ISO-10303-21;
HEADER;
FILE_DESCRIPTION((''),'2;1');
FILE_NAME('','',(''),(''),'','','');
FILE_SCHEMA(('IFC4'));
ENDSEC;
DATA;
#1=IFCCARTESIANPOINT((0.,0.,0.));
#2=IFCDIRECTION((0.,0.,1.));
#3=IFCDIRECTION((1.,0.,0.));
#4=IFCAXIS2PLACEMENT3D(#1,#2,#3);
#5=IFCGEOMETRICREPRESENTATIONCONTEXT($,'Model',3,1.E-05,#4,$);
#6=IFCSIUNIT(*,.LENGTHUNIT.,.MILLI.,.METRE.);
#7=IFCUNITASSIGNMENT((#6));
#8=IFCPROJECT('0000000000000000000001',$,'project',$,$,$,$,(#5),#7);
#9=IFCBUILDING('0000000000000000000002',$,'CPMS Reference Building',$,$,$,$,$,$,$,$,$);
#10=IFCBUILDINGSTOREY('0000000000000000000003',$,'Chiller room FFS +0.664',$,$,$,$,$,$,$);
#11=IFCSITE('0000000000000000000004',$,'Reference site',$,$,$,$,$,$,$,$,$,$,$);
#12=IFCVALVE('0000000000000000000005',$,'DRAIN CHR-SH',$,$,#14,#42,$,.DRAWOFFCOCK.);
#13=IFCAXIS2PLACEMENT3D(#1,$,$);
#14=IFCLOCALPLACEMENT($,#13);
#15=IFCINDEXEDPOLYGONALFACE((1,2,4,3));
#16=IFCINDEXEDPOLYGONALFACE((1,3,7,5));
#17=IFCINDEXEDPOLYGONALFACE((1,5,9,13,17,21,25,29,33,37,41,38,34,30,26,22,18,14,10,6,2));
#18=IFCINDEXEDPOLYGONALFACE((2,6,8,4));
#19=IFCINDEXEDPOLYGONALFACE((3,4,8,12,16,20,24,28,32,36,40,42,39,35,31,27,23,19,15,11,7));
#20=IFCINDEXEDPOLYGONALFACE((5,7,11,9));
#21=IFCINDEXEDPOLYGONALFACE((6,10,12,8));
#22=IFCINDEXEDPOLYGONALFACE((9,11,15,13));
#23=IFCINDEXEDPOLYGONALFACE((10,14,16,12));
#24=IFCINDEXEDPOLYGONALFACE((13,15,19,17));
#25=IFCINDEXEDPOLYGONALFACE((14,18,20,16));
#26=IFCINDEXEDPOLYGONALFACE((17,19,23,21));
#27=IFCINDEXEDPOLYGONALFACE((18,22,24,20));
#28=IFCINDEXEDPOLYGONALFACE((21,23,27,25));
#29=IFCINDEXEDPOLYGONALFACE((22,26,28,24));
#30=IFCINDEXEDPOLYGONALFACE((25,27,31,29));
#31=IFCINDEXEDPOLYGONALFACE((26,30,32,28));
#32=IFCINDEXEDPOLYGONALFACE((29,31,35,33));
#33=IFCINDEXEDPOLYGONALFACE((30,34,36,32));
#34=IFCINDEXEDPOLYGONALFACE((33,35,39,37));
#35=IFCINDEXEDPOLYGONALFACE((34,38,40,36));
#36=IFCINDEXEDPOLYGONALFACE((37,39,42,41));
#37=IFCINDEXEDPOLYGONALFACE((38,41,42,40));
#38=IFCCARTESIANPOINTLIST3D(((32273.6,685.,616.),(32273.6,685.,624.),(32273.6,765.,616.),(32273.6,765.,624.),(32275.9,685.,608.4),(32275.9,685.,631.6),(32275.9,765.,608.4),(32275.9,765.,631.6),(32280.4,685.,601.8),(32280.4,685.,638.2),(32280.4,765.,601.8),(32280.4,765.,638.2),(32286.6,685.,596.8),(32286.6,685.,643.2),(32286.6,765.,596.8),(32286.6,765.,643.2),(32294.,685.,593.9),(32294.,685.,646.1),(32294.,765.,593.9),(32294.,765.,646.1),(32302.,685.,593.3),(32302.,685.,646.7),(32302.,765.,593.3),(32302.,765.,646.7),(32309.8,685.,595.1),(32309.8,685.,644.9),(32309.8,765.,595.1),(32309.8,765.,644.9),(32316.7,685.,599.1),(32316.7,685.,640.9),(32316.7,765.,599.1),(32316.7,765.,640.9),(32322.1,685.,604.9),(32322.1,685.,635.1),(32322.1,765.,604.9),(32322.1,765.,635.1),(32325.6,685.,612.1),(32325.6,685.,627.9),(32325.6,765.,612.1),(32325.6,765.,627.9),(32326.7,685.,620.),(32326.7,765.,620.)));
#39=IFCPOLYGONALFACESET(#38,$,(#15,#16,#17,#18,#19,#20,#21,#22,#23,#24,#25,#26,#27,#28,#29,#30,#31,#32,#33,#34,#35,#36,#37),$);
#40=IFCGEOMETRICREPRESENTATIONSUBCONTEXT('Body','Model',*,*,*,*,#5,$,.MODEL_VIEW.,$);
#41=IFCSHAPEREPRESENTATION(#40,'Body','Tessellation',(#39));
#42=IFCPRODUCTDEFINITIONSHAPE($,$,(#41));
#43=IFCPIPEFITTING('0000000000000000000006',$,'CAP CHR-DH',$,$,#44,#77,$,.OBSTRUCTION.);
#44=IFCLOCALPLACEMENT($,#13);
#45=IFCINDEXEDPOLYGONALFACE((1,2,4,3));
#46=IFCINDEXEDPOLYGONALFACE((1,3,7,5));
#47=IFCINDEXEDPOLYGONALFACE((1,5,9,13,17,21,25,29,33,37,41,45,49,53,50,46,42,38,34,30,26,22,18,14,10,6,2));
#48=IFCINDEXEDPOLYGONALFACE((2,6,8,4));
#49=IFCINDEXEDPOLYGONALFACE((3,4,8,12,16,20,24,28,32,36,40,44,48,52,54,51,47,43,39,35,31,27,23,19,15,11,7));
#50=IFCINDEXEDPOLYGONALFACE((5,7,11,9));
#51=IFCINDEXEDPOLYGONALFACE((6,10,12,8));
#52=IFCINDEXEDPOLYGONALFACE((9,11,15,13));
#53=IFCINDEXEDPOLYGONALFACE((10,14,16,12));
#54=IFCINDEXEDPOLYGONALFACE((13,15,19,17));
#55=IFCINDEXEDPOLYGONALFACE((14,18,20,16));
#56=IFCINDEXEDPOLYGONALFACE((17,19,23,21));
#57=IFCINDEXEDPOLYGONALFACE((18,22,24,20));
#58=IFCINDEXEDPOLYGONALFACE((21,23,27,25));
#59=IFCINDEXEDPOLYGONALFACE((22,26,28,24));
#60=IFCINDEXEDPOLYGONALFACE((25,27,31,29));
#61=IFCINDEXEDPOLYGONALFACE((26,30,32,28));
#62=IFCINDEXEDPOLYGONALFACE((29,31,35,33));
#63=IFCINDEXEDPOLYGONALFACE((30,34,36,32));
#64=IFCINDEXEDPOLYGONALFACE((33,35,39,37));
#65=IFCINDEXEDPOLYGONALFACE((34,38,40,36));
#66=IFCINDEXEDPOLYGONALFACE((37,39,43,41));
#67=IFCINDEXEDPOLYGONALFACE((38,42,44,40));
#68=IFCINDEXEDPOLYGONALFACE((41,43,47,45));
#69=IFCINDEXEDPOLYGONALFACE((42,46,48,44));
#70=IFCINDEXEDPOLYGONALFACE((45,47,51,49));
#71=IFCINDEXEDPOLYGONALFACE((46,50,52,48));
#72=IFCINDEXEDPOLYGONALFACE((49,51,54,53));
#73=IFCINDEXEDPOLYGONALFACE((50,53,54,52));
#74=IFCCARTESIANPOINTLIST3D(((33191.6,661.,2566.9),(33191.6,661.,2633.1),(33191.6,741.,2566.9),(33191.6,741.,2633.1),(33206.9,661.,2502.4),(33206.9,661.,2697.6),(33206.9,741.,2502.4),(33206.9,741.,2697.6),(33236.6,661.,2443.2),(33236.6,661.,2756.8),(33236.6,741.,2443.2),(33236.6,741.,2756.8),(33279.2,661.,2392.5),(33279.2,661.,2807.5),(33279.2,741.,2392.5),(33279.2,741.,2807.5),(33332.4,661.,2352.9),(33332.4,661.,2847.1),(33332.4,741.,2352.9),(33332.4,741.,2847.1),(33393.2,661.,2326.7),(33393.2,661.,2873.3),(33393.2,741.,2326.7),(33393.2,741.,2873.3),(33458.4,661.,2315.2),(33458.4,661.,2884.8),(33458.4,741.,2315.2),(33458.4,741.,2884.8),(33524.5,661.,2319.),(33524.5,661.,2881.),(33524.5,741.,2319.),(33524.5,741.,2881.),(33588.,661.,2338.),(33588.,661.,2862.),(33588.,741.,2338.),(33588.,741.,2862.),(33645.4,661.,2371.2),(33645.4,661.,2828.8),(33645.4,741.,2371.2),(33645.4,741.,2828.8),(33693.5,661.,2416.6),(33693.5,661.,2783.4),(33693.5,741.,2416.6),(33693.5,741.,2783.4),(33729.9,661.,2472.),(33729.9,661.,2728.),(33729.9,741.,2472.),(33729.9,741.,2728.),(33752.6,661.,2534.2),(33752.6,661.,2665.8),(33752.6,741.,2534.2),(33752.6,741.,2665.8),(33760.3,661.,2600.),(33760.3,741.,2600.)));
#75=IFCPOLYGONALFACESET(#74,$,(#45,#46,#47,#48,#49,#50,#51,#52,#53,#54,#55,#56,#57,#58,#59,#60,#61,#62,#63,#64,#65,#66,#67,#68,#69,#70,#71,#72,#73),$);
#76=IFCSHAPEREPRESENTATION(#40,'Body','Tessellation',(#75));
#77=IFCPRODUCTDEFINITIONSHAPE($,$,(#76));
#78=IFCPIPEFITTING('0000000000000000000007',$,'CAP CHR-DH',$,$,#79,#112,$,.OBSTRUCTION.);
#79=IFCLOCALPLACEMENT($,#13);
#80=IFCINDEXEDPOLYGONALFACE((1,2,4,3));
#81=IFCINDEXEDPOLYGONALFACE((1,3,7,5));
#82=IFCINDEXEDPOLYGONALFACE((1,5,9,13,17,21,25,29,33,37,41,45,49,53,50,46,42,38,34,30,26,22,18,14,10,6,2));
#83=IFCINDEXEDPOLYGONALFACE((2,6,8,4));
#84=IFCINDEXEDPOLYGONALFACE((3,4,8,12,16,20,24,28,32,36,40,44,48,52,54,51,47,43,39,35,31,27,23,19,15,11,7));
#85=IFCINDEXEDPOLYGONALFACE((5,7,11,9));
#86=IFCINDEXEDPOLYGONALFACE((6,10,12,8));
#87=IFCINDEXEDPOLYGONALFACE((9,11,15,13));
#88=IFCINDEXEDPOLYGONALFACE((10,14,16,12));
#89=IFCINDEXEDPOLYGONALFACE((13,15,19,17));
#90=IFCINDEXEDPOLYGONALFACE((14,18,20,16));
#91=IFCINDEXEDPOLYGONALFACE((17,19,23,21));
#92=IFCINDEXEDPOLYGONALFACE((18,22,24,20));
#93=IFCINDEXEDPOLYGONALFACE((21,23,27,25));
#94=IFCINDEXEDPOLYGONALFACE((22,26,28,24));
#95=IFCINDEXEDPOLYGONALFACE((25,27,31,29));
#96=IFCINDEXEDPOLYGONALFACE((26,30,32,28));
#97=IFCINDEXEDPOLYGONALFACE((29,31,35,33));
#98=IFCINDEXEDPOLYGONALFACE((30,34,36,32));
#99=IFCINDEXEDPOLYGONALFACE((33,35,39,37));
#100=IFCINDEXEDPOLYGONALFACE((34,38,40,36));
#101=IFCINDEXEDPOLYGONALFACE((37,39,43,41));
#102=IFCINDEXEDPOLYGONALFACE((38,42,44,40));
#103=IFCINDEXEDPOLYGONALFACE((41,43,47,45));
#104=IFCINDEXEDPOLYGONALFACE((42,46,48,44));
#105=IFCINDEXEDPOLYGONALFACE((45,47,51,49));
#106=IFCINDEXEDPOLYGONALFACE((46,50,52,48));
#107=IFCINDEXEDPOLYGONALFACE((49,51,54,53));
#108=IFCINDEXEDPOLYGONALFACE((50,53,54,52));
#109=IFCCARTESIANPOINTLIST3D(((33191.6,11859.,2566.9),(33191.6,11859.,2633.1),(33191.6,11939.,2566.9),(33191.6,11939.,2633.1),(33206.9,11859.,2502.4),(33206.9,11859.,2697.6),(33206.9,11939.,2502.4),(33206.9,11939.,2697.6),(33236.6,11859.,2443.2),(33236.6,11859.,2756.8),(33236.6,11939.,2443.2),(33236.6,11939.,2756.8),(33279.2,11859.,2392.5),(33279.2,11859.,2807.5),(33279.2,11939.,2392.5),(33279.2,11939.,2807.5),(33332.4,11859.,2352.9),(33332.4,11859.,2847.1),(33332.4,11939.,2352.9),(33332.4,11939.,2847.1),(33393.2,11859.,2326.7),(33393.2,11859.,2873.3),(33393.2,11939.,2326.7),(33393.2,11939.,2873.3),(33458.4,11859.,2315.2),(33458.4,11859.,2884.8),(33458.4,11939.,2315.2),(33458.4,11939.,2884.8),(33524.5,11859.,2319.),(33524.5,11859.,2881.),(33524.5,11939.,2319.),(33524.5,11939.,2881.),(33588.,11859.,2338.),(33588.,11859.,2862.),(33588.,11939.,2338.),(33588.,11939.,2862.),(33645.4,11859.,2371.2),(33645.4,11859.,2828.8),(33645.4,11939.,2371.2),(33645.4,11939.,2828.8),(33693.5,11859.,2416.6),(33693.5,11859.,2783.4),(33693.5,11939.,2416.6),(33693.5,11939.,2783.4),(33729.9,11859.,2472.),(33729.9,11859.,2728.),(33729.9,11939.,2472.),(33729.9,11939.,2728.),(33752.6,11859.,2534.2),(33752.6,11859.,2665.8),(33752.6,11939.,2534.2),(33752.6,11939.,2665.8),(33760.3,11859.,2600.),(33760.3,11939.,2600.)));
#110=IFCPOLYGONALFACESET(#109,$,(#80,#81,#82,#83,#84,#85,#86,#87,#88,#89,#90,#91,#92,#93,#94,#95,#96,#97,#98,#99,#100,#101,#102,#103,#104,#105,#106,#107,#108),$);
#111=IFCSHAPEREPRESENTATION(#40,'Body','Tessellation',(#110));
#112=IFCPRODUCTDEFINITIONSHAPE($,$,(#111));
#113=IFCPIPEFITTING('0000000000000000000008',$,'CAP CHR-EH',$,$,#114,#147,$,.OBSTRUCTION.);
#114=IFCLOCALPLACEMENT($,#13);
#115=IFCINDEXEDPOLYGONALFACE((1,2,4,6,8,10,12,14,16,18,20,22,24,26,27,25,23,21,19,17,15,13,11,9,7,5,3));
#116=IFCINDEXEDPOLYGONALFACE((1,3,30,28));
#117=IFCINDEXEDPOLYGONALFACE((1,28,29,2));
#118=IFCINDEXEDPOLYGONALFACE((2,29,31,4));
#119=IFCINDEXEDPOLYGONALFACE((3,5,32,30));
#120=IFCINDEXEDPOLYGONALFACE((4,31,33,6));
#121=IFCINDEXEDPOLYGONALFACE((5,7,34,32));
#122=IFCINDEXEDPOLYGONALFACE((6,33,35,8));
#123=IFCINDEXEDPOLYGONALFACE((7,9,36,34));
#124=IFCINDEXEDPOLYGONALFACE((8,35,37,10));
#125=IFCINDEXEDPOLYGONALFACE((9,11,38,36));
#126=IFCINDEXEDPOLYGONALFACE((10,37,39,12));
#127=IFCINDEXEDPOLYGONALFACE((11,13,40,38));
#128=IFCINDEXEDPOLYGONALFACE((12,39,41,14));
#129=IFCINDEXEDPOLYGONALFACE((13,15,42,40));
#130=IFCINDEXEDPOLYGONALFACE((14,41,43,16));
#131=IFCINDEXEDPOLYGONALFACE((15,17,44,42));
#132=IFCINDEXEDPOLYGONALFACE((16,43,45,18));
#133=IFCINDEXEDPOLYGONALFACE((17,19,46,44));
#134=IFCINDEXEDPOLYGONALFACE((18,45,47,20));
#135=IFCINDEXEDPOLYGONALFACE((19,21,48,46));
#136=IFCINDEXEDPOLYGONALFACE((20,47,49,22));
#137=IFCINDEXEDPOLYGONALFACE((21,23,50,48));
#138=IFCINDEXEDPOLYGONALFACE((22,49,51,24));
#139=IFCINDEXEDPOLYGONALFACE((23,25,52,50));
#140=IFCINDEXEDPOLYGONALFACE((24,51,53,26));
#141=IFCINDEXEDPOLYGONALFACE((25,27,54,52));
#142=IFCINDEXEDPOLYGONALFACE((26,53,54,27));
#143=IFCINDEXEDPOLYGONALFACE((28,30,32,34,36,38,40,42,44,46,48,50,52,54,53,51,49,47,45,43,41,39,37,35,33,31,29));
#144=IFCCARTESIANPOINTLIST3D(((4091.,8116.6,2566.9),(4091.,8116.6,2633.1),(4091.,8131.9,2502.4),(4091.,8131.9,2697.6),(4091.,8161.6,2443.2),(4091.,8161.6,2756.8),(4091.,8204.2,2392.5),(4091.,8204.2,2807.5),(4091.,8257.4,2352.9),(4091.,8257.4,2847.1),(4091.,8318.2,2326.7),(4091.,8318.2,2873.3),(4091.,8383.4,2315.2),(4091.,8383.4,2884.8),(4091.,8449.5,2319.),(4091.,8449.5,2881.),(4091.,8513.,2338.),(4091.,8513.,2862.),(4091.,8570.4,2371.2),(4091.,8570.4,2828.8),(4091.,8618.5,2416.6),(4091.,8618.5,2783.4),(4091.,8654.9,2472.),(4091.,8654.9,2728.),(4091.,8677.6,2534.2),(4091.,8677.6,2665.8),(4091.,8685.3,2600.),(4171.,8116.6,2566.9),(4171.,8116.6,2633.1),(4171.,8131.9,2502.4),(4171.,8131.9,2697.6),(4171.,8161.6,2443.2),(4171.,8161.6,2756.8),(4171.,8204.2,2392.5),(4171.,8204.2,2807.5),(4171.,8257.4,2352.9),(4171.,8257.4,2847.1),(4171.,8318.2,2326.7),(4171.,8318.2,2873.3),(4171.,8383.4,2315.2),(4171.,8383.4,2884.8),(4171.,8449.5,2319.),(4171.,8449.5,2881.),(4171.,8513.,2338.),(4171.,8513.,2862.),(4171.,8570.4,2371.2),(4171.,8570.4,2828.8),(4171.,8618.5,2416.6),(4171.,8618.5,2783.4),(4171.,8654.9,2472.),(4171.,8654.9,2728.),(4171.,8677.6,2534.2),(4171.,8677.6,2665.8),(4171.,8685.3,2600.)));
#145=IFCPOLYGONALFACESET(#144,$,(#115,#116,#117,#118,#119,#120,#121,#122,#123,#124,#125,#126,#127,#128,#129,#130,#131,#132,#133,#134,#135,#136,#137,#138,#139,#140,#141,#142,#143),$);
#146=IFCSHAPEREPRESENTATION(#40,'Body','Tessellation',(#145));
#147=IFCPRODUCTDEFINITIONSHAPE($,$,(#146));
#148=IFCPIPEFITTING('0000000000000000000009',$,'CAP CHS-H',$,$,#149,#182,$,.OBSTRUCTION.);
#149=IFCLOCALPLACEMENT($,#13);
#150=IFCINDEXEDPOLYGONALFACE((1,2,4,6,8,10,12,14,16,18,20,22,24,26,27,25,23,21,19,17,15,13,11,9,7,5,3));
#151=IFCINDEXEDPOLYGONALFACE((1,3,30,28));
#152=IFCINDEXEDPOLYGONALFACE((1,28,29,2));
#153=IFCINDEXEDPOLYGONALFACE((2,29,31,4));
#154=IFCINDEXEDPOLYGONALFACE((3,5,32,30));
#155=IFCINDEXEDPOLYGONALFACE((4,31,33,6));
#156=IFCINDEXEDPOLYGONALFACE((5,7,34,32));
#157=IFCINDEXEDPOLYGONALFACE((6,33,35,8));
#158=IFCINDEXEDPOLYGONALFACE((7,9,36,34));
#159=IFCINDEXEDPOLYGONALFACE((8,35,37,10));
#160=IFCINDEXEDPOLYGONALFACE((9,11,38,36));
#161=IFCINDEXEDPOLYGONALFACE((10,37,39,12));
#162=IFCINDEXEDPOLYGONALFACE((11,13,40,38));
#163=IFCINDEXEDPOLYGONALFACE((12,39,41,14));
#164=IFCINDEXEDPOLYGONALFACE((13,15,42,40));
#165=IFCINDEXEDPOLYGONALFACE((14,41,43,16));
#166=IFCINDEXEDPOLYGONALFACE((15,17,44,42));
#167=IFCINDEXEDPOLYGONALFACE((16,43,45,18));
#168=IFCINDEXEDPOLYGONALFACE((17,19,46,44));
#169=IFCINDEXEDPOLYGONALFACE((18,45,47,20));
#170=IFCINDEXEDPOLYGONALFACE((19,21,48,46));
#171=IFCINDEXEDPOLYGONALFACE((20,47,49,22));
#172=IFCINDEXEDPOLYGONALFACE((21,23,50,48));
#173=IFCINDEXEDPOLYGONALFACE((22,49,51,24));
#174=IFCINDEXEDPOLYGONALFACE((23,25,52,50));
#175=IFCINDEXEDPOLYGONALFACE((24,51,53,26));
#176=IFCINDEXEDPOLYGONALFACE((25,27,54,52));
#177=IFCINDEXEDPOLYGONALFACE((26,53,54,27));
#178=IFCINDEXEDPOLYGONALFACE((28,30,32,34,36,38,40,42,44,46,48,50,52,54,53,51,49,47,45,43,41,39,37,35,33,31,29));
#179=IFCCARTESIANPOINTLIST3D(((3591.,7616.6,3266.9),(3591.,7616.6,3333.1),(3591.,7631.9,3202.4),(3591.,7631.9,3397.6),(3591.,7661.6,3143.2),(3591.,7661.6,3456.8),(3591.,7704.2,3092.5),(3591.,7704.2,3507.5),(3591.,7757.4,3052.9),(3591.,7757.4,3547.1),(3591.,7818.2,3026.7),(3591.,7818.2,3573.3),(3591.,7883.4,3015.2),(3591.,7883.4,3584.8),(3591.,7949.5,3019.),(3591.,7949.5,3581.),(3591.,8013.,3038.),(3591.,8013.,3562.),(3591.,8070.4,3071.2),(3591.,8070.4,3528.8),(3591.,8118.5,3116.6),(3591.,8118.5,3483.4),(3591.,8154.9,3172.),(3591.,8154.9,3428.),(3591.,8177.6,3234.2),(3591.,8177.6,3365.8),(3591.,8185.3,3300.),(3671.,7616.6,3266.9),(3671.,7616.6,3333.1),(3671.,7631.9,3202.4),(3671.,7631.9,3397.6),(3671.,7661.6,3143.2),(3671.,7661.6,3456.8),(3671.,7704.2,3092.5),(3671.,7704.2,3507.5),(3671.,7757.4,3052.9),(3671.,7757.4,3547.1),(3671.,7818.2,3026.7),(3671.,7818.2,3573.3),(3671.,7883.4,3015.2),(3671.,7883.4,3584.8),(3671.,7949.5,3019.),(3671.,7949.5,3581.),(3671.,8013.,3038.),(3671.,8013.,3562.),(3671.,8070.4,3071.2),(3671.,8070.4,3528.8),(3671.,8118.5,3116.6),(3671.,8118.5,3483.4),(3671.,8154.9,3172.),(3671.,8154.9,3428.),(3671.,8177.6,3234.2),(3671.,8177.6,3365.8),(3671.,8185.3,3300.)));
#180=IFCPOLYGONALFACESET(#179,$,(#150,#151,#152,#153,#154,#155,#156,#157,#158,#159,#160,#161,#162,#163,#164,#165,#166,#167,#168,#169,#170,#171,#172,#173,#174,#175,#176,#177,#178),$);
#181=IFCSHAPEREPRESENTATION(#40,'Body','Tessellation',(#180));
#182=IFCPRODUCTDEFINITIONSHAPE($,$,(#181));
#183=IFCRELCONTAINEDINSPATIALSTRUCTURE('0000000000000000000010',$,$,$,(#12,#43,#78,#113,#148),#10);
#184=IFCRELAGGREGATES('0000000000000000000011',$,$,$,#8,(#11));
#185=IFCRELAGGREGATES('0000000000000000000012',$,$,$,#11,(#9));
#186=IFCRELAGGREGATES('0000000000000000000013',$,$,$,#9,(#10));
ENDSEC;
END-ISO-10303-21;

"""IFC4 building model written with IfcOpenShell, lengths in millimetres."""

from ifc_helpers import new_model, si_unit, frame, origin_with_axes, origin_2d, place, context, subcontext, project, spatial, circle_curve, outline, extrude, element, save


model = new_model("IFC4")

# Units and contexts
model_context = context("Model", 3, precision=1e-05, world=origin_with_axes())
body_context = subcontext(model_context, "Body", "Model", "MODEL_VIEW")
ifc_project = project(units=[si_unit("LENGTHUNIT", "METRE", prefix="MILLI")], contexts=[model_context])

# Site, building, storey
site = spatial("IfcSite", under=ifc_project, Name="Reference site")
building = spatial("IfcBuilding", under=site, Name="CPMS Reference Building")
storey = spatial("IfcBuildingStorey", under=building, Name="Chiller room FFS +0.664")

# Valve
valve_1_placement = place(None, origin_with_axes())
element("IfcValve", 1, at=valve_1_placement, inside=storey, Name="DRAIN CHR-SH", PredefinedType="DRAWOFFCOCK", context=body_context, shape_type="SweptSolid", body=[
    extrude(outline(circle_curve(origin_2d(), 26.7)), frame((32300.0, 765.0, 620.0), z_axis=(0.0, -1.0, 0.0), x_axis=(1.0, 0.0, 0.0)), (0.0, 0.0, 1.0), 80.0),
])

# Pipe fittings
pipe_fitting_1_placement = place(None, origin_with_axes())
element("IfcPipeFitting", 2, at=pipe_fitting_1_placement, inside=storey, Name="CAP CHR-DH", PredefinedType="OBSTRUCTION", context=body_context, shape_type="SweptSolid", body=[
    extrude(outline(circle_curve(origin_2d(), 285.3)), frame((33475.0, 661.0, 2600.0), z_axis=(0.0, 1.0, 0.0), x_axis=(1.0, 0.0, 0.0)), (0.0, 0.0, 1.0), 80.0),
])
pipe_fitting_2_placement = place(None, origin_with_axes())
element("IfcPipeFitting", 3, at=pipe_fitting_2_placement, inside=storey, Name="CAP CHR-DH", PredefinedType="OBSTRUCTION", context=body_context, shape_type="SweptSolid", body=[
    extrude(outline(circle_curve(origin_2d(), 285.3)), frame((33475.0, 11859.0, 2600.0), z_axis=(0.0, 1.0, 0.0), x_axis=(1.0, 0.0, 0.0)), (0.0, 0.0, 1.0), 80.0),
])
pipe_fitting_3_placement = place(None, origin_with_axes())
element("IfcPipeFitting", 4, at=pipe_fitting_3_placement, inside=storey, Name="CAP CHR-EH", PredefinedType="OBSTRUCTION", context=body_context, shape_type="SweptSolid", body=[
    extrude(outline(circle_curve(origin_2d(), 285.3)), frame((4171.0, 8400.0, 2600.0), z_axis=(-1.0, 0.0, 0.0), x_axis=(0.0, 1.0, 0.0)), (0.0, 0.0, 1.0), 80.0),
])
pipe_fitting_4_placement = place(None, origin_with_axes())
element("IfcPipeFitting", 5, at=pipe_fitting_4_placement, inside=storey, Name="CAP CHS-H", PredefinedType="OBSTRUCTION", context=body_context, shape_type="SweptSolid", body=[
    extrude(outline(circle_curve(origin_2d(), 285.3)), frame((3591.0, 7900.0, 3300.0), z_axis=(1.0, 0.0, 0.0), x_axis=(0.0, 1.0, 0.0)), (0.0, 0.0, 1.0), 80.0),
])

save(model, "model.ifc")
